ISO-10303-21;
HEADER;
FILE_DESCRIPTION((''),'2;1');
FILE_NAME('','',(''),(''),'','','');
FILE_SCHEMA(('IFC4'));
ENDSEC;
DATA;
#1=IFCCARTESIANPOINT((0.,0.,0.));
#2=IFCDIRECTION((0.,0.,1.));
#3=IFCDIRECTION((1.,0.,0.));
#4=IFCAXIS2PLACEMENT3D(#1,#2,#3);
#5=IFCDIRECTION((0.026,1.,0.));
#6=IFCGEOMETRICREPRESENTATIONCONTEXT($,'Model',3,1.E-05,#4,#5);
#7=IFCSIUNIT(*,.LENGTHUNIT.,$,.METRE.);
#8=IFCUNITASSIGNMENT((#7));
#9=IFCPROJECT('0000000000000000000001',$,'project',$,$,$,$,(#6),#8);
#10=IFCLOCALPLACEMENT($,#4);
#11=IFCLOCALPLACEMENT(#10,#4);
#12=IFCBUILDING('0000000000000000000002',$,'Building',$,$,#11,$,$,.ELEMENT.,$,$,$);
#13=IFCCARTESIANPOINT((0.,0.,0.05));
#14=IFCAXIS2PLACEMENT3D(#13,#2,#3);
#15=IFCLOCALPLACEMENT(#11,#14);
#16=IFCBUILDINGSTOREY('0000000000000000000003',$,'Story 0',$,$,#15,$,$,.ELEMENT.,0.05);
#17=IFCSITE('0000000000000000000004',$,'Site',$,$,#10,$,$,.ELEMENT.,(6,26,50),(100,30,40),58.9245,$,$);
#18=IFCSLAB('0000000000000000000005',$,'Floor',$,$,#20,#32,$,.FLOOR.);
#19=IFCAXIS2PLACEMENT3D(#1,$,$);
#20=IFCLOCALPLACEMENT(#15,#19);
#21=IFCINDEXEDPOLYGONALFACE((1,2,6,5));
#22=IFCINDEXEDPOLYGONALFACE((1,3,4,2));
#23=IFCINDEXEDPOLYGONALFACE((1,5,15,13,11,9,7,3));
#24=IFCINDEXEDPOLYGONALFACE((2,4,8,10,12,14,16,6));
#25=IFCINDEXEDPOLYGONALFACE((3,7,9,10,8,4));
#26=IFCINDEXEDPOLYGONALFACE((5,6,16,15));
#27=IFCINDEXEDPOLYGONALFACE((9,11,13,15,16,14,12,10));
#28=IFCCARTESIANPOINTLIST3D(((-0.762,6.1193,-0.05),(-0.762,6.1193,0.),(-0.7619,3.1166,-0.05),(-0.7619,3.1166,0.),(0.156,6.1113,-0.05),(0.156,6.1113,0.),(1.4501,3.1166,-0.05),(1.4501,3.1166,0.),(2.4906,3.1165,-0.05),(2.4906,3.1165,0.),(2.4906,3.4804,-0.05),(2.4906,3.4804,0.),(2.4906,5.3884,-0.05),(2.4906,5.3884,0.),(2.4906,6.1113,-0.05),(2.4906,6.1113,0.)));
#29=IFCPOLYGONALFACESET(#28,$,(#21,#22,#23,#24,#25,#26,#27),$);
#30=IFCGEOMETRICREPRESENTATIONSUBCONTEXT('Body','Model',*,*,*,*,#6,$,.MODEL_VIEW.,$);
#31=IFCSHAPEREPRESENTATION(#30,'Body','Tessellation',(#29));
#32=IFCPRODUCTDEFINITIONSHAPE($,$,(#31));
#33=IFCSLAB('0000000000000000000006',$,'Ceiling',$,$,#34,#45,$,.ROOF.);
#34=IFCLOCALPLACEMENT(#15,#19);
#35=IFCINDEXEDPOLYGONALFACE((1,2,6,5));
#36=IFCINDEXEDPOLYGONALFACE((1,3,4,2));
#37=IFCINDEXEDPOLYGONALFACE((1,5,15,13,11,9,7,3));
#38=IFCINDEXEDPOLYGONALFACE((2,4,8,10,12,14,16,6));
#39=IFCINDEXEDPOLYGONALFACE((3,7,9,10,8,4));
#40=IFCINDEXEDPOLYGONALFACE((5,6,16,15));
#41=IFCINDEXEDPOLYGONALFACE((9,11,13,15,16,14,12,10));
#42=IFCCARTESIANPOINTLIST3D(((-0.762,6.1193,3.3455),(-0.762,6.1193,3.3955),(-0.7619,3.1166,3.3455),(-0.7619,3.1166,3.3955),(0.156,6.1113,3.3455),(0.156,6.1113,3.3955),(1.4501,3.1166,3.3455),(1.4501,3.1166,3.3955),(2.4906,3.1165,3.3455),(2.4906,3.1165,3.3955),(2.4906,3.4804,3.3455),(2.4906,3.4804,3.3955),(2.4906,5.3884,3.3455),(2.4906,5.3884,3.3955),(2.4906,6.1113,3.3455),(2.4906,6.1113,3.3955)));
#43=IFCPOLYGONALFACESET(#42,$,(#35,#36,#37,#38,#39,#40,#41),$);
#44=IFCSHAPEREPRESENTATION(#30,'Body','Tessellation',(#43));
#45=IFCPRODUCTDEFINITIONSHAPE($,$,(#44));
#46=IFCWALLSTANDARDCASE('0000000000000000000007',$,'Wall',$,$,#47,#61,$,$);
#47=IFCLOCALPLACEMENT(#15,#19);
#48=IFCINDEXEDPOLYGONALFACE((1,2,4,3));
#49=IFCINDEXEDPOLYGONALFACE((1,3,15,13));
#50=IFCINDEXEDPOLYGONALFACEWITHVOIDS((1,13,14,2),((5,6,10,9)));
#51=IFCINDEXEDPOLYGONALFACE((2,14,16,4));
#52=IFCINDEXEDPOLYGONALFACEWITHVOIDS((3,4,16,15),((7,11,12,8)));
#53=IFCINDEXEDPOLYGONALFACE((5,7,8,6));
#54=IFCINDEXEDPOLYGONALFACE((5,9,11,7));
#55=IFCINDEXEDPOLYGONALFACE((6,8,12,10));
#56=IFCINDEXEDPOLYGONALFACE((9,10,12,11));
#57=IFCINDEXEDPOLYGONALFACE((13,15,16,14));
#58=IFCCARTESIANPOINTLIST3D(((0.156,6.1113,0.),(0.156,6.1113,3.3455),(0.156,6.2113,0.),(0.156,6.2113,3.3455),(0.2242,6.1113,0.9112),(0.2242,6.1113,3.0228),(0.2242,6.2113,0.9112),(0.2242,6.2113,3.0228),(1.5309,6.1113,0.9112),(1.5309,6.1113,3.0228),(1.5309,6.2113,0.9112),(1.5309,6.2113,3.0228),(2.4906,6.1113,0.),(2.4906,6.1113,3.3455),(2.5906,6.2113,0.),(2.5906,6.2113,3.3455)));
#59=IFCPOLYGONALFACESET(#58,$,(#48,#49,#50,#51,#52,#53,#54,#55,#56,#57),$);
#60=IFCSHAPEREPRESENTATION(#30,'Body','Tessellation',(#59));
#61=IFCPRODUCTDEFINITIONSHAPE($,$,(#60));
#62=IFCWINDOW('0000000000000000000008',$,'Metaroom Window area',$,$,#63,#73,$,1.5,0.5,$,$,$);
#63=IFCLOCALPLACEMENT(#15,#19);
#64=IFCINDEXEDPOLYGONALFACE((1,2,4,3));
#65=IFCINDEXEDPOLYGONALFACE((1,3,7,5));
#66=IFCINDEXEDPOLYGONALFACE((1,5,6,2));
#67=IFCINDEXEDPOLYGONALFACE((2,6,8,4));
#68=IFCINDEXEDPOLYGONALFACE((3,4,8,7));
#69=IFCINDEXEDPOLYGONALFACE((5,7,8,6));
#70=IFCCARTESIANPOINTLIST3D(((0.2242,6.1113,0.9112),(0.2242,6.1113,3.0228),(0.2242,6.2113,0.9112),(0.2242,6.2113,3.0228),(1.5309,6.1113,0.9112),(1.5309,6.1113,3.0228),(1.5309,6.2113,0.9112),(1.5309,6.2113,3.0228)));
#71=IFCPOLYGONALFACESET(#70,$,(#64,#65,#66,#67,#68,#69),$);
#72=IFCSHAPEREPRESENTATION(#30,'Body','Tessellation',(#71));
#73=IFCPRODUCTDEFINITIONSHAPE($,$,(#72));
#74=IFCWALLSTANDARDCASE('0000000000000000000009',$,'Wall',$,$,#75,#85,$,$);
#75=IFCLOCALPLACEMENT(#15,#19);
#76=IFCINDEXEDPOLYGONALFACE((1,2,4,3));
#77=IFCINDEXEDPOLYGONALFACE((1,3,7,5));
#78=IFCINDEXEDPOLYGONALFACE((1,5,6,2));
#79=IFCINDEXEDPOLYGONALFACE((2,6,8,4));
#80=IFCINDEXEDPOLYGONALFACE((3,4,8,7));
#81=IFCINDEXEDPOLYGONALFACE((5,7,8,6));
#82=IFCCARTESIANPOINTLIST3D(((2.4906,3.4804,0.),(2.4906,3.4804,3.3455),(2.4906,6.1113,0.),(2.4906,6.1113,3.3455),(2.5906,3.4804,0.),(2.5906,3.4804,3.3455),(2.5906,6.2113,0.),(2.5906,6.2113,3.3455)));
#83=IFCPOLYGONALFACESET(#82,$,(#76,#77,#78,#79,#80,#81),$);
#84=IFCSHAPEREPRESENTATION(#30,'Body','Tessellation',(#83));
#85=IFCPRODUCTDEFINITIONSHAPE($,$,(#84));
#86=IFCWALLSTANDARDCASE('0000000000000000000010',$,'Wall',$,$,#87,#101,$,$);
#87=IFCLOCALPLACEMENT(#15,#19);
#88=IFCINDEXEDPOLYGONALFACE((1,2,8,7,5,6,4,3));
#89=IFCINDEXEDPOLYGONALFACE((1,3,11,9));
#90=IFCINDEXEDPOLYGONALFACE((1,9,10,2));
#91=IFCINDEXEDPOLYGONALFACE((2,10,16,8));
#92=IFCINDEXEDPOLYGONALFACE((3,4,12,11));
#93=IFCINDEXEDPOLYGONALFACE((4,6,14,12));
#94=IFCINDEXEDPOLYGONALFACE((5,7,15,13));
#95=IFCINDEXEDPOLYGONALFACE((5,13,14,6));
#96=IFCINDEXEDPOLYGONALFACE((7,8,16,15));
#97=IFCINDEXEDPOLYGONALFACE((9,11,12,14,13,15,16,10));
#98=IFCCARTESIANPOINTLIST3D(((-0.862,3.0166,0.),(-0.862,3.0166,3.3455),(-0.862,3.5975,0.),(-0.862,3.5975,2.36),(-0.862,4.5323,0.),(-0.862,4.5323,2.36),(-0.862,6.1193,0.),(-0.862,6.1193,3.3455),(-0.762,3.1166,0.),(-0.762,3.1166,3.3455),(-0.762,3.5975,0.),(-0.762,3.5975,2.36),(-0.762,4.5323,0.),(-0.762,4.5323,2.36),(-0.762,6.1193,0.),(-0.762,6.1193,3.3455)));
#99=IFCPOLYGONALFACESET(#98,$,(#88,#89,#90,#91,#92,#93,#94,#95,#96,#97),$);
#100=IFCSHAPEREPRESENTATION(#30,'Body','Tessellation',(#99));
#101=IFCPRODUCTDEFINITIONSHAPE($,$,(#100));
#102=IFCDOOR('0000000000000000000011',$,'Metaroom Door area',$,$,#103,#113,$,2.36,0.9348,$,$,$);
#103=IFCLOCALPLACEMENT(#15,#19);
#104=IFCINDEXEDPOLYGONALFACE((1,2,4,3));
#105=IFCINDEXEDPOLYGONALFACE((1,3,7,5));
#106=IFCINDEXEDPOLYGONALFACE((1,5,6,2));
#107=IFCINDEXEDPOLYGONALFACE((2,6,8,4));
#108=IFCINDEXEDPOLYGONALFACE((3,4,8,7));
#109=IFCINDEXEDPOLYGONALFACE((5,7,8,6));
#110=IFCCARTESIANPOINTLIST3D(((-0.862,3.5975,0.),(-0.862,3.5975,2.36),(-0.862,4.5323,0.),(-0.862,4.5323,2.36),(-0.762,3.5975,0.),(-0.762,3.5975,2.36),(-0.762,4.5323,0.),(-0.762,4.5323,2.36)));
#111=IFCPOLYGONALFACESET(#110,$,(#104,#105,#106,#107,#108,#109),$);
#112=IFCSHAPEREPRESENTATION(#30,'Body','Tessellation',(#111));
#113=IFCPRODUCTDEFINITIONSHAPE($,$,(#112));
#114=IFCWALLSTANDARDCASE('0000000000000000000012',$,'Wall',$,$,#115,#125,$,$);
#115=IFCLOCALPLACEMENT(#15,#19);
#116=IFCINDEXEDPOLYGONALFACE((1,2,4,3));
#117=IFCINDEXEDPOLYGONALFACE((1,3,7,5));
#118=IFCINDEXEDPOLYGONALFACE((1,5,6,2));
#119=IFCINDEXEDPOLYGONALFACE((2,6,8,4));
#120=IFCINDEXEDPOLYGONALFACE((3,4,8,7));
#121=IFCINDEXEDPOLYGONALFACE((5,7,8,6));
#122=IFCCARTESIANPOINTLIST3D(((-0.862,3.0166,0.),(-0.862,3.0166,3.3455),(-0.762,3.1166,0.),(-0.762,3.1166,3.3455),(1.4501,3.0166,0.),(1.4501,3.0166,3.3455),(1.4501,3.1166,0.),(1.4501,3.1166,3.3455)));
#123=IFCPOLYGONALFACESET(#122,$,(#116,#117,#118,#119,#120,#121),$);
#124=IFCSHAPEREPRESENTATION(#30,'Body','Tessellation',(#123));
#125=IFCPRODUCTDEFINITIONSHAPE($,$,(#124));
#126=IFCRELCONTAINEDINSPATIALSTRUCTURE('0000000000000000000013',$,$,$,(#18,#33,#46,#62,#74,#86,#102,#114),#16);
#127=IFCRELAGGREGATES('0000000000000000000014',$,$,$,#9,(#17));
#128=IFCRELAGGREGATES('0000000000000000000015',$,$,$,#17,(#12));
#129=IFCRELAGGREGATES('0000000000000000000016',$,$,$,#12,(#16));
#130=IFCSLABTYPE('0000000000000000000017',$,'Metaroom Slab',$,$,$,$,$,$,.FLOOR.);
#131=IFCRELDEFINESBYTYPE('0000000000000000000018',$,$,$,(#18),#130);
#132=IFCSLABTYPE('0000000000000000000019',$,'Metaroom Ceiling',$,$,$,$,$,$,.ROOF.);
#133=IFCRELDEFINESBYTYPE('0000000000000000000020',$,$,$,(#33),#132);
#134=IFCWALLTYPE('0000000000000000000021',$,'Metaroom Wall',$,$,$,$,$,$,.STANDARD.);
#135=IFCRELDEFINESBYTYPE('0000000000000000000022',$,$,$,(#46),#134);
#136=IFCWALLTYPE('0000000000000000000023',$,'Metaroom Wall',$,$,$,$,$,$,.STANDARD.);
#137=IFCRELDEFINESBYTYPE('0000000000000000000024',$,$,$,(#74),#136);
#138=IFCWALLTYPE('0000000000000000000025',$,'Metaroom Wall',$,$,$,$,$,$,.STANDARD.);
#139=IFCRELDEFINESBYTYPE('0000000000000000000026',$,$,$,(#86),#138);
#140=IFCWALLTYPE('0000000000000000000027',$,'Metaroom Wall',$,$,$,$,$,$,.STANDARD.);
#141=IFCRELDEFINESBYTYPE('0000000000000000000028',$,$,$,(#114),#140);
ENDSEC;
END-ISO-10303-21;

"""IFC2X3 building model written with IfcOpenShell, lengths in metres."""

from ifc_helpers import new_model, si_unit, direction, frame, origin_with_axes, place, context, subcontext, project, spatial, polyline, outline, extrude, type_object, element, fill, save


model = new_model("IFC2X3")

# Units and contexts
model_context = context("Model", 3, precision=1e-05, world=origin_with_axes(), true_north=direction((0.026, 1.0, 0.0)))
body_context = subcontext(model_context, "Body", "Model", "MODEL_VIEW")
ifc_project = project(units=[si_unit("LENGTHUNIT", "METRE")], contexts=[model_context])

# Site, building, storey
site_placement = place(None, origin_with_axes())
site = spatial("IfcSite", under=ifc_project, at=site_placement, Name="Site", CompositionType="ELEMENT", RefLatitude=(6, 26, 50), RefLongitude=(100, 30, 40), RefElevation=58.9245)
building_placement = place(site_placement, origin_with_axes())
building = spatial("IfcBuilding", under=site, at=building_placement, Name="Building", CompositionType="ELEMENT")
storey_placement = place(building_placement, frame((0.0, 0.0, 0.05), z_axis=(0.0, 0.0, 1.0), x_axis=(1.0, 0.0, 0.0)))
storey = spatial("IfcBuildingStorey", under=building, at=storey_placement, Name="Story 0", CompositionType="ELEMENT", Elevation=0.05)

# Slabs
slab_type_1 = type_object("IfcSlabType", Name="Metaroom Slab", PredefinedType="FLOOR")
slab_1_placement = place(storey_placement, frame((-0.762, 6.1193, 0.0), z_axis=(0.0, 0.0, 1.0), x_axis=(1.0, 0.0, 0.0)))
element("IfcSlab", 1, at=slab_1_placement, inside=storey, type_object=slab_type_1, Name="Floor", PredefinedType="FLOOR", context=body_context, shape_type="SweptSolid", body=[
    extrude(outline(polyline([(0.0, 0.0), (0.0, -3.0027), (2.212, -3.0028), (3.2525, -3.0028), (3.2525, -2.639), (3.2525, -0.7309), (3.2526, -0.0081), (0.918, -0.008), (0.0, 0.0)])), origin_with_axes(), (0.0, 0.0, -1.0), 0.05),
])
slab_type_2 = type_object("IfcSlabType", Name="Metaroom Ceiling", PredefinedType="ROOF")
slab_2_placement = place(storey_placement, frame((-0.762, 6.1193, 3.3455), z_axis=(0.0, 0.0, 1.0), x_axis=(1.0, 0.0, 0.0)))
element("IfcSlab", 2, at=slab_2_placement, inside=storey, type_object=slab_type_2, Name="Ceiling", PredefinedType="ROOF", context=body_context, shape_type="SweptSolid", body=[
    extrude(outline(polyline([(0.0, 0.0), (0.0, -3.0027), (2.212, -3.0028), (3.2525, -3.0028), (3.2525, -2.639), (3.2525, -0.7309), (3.2526, -0.0081), (0.918, -0.008), (0.0, 0.0)])), origin_with_axes(), (0.0, 0.0, 1.0), 0.05),
])

# Wall, opening, window
wall_type_1 = type_object("IfcWallType", Name="Metaroom Wall", PredefinedType="STANDARD")
wall_1_placement = place(storey_placement, frame((0.156, 6.1113, 0.0), z_axis=(0.0, 0.0, 1.0), x_axis=(1.0, 0.0, 0.0)))
wall_1 = element("IfcWallStandardCase", 3, at=wall_1_placement, inside=storey, type_object=wall_type_1, Name="Wall", context=body_context, shape_type="SweptSolid", body=[
    extrude(outline(polyline([(0.0, 0.0), (0.0, 0.1), (2.4346, 0.1), (2.3346, 0.0), (0.0, 0.0)])), origin_with_axes(), (0.0, 0.0, 1.0), 3.3455),
])
opening_1_placement = place(wall_1_placement, frame((0.0681, 0.0, 0.9112), z_axis=(0.0, 0.0, 1.0), x_axis=(1.0, 0.0, 0.0)))
opening_1 = element("IfcOpeningElement", 4, at=opening_1_placement, cuts=wall_1, ObjectType="OPENING", context=body_context, shape_type="SweptSolid", body=[
    extrude(outline(polyline([(0.0, 0.0), (1.3067, 0.0), (1.3067, 2.1116), (0.0, 2.1116), (0.0, 0.0)])), frame((0.0, 0.0, 0.0), z_axis=(0.0, -1.0, 0.0), x_axis=(1.0, 0.0, 0.0)), (0.0, 0.0, -1.0), 0.1001),
])
window_placement = place(opening_1_placement, origin_with_axes())
window = element("IfcWindow", 5, at=window_placement, inside=storey, Name="Metaroom Window area", OverallHeight=1.5, OverallWidth=0.5, context=body_context, shape_type="SweptSolid", body=[
    extrude(outline(polyline([(0.0, 0.0), (-1.3067, 0.0), (-1.3067, 2.1116), (0.0, 2.1116), (0.0, 0.0)])), frame((0.0, 0.1, 0.0), z_axis=(0.0, 1.0, 0.0), x_axis=(-1.0, 0.0, 0.0)), (0.0, 0.0, -1.0), 0.1),
])
fill(opening_1, window)

# Wall
wall_type_2 = type_object("IfcWallType", Name="Metaroom Wall", PredefinedType="STANDARD")
wall_2_placement = place(storey_placement, frame((2.4906, 6.1113, 0.0), z_axis=(0.0, 0.0, 1.0), x_axis=(1.0, 0.0, 0.0)))
element("IfcWallStandardCase", 6, at=wall_2_placement, inside=storey, type_object=wall_type_2, Name="Wall", context=body_context, shape_type="SweptSolid", body=[
    extrude(outline(polyline([(0.0, 0.0), (0.1, 0.1), (0.1, -2.6309), (0.0, -2.6309), (0.0, 0.0)])), origin_with_axes(), (0.0, 0.0, 1.0), 3.3455),
])

# Wall, opening, door
wall_type_3 = type_object("IfcWallType", Name="Metaroom Wall", PredefinedType="STANDARD")
wall_3_placement = place(storey_placement, frame((-0.862, 6.1193, 0.0), z_axis=(0.0, 0.0, 1.0), x_axis=(1.0, 0.0, 0.0)))
wall_3 = element("IfcWallStandardCase", 7, at=wall_3_placement, inside=storey, type_object=wall_type_3, Name="Wall", context=body_context, shape_type="SweptSolid", body=[
    extrude(outline(polyline([(0.0, 0.0), (0.1, 0.0), (0.1, -3.0027), (0.0, -3.1027), (0.0, 0.0)])), origin_with_axes(), (0.0, 0.0, 1.0), 3.3455),
])
opening_2_placement = place(wall_3_placement, frame((0.1, -2.5218, 0.0), z_axis=(0.0, 0.0, 1.0), x_axis=(0.0, 1.0, 0.0)))
opening_2 = element("IfcOpeningElement", 8, at=opening_2_placement, cuts=wall_3, ObjectType="OPENING", context=body_context, shape_type="SweptSolid", body=[
    extrude(outline(polyline([(0.0, 0.0), (0.9348, 0.0), (0.9348, 2.36), (0.0, 2.36), (0.0, 0.0)])), frame((0.0, 0.0, 0.0), z_axis=(0.0, -1.0, 0.0), x_axis=(1.0, 0.0, 0.0)), (0.0, 0.0, -1.0), 0.1001),
])
door_placement = place(opening_2_placement, origin_with_axes())
door = element("IfcDoor", 9, at=door_placement, inside=storey, Name="Metaroom Door area", OverallHeight=2.36, OverallWidth=0.9348, context=body_context, shape_type="SweptSolid", body=[
    extrude(outline(polyline([(0.0, 0.0), (-0.9348, 0.0), (-0.9348, 2.36), (0.0, 2.36), (0.0, 0.0)])), frame((0.0, 0.1, 0.0), z_axis=(0.0, 1.0, 0.0), x_axis=(-1.0, 0.0, 0.0)), (0.0, 0.0, -1.0), 0.1),
])
fill(opening_2, door)

# Wall
wall_type_4 = type_object("IfcWallType", Name="Metaroom Wall", PredefinedType="STANDARD")
wall_4_placement = place(storey_placement, frame((-0.862, 3.0166, 0.0), z_axis=(0.0, 0.0, 1.0), x_axis=(1.0, 0.0, 0.0)))
element("IfcWallStandardCase", 10, at=wall_4_placement, inside=storey, type_object=wall_type_4, Name="Wall", context=body_context, shape_type="SweptSolid", body=[
    extrude(outline(polyline([(0.0, 0.0), (0.1, 0.1), (2.312, 0.1), (2.312, 0.0), (0.0, 0.0)])), origin_with_axes(), (0.0, 0.0, 1.0), 3.3455),
])

save(model, "model.ifc")
